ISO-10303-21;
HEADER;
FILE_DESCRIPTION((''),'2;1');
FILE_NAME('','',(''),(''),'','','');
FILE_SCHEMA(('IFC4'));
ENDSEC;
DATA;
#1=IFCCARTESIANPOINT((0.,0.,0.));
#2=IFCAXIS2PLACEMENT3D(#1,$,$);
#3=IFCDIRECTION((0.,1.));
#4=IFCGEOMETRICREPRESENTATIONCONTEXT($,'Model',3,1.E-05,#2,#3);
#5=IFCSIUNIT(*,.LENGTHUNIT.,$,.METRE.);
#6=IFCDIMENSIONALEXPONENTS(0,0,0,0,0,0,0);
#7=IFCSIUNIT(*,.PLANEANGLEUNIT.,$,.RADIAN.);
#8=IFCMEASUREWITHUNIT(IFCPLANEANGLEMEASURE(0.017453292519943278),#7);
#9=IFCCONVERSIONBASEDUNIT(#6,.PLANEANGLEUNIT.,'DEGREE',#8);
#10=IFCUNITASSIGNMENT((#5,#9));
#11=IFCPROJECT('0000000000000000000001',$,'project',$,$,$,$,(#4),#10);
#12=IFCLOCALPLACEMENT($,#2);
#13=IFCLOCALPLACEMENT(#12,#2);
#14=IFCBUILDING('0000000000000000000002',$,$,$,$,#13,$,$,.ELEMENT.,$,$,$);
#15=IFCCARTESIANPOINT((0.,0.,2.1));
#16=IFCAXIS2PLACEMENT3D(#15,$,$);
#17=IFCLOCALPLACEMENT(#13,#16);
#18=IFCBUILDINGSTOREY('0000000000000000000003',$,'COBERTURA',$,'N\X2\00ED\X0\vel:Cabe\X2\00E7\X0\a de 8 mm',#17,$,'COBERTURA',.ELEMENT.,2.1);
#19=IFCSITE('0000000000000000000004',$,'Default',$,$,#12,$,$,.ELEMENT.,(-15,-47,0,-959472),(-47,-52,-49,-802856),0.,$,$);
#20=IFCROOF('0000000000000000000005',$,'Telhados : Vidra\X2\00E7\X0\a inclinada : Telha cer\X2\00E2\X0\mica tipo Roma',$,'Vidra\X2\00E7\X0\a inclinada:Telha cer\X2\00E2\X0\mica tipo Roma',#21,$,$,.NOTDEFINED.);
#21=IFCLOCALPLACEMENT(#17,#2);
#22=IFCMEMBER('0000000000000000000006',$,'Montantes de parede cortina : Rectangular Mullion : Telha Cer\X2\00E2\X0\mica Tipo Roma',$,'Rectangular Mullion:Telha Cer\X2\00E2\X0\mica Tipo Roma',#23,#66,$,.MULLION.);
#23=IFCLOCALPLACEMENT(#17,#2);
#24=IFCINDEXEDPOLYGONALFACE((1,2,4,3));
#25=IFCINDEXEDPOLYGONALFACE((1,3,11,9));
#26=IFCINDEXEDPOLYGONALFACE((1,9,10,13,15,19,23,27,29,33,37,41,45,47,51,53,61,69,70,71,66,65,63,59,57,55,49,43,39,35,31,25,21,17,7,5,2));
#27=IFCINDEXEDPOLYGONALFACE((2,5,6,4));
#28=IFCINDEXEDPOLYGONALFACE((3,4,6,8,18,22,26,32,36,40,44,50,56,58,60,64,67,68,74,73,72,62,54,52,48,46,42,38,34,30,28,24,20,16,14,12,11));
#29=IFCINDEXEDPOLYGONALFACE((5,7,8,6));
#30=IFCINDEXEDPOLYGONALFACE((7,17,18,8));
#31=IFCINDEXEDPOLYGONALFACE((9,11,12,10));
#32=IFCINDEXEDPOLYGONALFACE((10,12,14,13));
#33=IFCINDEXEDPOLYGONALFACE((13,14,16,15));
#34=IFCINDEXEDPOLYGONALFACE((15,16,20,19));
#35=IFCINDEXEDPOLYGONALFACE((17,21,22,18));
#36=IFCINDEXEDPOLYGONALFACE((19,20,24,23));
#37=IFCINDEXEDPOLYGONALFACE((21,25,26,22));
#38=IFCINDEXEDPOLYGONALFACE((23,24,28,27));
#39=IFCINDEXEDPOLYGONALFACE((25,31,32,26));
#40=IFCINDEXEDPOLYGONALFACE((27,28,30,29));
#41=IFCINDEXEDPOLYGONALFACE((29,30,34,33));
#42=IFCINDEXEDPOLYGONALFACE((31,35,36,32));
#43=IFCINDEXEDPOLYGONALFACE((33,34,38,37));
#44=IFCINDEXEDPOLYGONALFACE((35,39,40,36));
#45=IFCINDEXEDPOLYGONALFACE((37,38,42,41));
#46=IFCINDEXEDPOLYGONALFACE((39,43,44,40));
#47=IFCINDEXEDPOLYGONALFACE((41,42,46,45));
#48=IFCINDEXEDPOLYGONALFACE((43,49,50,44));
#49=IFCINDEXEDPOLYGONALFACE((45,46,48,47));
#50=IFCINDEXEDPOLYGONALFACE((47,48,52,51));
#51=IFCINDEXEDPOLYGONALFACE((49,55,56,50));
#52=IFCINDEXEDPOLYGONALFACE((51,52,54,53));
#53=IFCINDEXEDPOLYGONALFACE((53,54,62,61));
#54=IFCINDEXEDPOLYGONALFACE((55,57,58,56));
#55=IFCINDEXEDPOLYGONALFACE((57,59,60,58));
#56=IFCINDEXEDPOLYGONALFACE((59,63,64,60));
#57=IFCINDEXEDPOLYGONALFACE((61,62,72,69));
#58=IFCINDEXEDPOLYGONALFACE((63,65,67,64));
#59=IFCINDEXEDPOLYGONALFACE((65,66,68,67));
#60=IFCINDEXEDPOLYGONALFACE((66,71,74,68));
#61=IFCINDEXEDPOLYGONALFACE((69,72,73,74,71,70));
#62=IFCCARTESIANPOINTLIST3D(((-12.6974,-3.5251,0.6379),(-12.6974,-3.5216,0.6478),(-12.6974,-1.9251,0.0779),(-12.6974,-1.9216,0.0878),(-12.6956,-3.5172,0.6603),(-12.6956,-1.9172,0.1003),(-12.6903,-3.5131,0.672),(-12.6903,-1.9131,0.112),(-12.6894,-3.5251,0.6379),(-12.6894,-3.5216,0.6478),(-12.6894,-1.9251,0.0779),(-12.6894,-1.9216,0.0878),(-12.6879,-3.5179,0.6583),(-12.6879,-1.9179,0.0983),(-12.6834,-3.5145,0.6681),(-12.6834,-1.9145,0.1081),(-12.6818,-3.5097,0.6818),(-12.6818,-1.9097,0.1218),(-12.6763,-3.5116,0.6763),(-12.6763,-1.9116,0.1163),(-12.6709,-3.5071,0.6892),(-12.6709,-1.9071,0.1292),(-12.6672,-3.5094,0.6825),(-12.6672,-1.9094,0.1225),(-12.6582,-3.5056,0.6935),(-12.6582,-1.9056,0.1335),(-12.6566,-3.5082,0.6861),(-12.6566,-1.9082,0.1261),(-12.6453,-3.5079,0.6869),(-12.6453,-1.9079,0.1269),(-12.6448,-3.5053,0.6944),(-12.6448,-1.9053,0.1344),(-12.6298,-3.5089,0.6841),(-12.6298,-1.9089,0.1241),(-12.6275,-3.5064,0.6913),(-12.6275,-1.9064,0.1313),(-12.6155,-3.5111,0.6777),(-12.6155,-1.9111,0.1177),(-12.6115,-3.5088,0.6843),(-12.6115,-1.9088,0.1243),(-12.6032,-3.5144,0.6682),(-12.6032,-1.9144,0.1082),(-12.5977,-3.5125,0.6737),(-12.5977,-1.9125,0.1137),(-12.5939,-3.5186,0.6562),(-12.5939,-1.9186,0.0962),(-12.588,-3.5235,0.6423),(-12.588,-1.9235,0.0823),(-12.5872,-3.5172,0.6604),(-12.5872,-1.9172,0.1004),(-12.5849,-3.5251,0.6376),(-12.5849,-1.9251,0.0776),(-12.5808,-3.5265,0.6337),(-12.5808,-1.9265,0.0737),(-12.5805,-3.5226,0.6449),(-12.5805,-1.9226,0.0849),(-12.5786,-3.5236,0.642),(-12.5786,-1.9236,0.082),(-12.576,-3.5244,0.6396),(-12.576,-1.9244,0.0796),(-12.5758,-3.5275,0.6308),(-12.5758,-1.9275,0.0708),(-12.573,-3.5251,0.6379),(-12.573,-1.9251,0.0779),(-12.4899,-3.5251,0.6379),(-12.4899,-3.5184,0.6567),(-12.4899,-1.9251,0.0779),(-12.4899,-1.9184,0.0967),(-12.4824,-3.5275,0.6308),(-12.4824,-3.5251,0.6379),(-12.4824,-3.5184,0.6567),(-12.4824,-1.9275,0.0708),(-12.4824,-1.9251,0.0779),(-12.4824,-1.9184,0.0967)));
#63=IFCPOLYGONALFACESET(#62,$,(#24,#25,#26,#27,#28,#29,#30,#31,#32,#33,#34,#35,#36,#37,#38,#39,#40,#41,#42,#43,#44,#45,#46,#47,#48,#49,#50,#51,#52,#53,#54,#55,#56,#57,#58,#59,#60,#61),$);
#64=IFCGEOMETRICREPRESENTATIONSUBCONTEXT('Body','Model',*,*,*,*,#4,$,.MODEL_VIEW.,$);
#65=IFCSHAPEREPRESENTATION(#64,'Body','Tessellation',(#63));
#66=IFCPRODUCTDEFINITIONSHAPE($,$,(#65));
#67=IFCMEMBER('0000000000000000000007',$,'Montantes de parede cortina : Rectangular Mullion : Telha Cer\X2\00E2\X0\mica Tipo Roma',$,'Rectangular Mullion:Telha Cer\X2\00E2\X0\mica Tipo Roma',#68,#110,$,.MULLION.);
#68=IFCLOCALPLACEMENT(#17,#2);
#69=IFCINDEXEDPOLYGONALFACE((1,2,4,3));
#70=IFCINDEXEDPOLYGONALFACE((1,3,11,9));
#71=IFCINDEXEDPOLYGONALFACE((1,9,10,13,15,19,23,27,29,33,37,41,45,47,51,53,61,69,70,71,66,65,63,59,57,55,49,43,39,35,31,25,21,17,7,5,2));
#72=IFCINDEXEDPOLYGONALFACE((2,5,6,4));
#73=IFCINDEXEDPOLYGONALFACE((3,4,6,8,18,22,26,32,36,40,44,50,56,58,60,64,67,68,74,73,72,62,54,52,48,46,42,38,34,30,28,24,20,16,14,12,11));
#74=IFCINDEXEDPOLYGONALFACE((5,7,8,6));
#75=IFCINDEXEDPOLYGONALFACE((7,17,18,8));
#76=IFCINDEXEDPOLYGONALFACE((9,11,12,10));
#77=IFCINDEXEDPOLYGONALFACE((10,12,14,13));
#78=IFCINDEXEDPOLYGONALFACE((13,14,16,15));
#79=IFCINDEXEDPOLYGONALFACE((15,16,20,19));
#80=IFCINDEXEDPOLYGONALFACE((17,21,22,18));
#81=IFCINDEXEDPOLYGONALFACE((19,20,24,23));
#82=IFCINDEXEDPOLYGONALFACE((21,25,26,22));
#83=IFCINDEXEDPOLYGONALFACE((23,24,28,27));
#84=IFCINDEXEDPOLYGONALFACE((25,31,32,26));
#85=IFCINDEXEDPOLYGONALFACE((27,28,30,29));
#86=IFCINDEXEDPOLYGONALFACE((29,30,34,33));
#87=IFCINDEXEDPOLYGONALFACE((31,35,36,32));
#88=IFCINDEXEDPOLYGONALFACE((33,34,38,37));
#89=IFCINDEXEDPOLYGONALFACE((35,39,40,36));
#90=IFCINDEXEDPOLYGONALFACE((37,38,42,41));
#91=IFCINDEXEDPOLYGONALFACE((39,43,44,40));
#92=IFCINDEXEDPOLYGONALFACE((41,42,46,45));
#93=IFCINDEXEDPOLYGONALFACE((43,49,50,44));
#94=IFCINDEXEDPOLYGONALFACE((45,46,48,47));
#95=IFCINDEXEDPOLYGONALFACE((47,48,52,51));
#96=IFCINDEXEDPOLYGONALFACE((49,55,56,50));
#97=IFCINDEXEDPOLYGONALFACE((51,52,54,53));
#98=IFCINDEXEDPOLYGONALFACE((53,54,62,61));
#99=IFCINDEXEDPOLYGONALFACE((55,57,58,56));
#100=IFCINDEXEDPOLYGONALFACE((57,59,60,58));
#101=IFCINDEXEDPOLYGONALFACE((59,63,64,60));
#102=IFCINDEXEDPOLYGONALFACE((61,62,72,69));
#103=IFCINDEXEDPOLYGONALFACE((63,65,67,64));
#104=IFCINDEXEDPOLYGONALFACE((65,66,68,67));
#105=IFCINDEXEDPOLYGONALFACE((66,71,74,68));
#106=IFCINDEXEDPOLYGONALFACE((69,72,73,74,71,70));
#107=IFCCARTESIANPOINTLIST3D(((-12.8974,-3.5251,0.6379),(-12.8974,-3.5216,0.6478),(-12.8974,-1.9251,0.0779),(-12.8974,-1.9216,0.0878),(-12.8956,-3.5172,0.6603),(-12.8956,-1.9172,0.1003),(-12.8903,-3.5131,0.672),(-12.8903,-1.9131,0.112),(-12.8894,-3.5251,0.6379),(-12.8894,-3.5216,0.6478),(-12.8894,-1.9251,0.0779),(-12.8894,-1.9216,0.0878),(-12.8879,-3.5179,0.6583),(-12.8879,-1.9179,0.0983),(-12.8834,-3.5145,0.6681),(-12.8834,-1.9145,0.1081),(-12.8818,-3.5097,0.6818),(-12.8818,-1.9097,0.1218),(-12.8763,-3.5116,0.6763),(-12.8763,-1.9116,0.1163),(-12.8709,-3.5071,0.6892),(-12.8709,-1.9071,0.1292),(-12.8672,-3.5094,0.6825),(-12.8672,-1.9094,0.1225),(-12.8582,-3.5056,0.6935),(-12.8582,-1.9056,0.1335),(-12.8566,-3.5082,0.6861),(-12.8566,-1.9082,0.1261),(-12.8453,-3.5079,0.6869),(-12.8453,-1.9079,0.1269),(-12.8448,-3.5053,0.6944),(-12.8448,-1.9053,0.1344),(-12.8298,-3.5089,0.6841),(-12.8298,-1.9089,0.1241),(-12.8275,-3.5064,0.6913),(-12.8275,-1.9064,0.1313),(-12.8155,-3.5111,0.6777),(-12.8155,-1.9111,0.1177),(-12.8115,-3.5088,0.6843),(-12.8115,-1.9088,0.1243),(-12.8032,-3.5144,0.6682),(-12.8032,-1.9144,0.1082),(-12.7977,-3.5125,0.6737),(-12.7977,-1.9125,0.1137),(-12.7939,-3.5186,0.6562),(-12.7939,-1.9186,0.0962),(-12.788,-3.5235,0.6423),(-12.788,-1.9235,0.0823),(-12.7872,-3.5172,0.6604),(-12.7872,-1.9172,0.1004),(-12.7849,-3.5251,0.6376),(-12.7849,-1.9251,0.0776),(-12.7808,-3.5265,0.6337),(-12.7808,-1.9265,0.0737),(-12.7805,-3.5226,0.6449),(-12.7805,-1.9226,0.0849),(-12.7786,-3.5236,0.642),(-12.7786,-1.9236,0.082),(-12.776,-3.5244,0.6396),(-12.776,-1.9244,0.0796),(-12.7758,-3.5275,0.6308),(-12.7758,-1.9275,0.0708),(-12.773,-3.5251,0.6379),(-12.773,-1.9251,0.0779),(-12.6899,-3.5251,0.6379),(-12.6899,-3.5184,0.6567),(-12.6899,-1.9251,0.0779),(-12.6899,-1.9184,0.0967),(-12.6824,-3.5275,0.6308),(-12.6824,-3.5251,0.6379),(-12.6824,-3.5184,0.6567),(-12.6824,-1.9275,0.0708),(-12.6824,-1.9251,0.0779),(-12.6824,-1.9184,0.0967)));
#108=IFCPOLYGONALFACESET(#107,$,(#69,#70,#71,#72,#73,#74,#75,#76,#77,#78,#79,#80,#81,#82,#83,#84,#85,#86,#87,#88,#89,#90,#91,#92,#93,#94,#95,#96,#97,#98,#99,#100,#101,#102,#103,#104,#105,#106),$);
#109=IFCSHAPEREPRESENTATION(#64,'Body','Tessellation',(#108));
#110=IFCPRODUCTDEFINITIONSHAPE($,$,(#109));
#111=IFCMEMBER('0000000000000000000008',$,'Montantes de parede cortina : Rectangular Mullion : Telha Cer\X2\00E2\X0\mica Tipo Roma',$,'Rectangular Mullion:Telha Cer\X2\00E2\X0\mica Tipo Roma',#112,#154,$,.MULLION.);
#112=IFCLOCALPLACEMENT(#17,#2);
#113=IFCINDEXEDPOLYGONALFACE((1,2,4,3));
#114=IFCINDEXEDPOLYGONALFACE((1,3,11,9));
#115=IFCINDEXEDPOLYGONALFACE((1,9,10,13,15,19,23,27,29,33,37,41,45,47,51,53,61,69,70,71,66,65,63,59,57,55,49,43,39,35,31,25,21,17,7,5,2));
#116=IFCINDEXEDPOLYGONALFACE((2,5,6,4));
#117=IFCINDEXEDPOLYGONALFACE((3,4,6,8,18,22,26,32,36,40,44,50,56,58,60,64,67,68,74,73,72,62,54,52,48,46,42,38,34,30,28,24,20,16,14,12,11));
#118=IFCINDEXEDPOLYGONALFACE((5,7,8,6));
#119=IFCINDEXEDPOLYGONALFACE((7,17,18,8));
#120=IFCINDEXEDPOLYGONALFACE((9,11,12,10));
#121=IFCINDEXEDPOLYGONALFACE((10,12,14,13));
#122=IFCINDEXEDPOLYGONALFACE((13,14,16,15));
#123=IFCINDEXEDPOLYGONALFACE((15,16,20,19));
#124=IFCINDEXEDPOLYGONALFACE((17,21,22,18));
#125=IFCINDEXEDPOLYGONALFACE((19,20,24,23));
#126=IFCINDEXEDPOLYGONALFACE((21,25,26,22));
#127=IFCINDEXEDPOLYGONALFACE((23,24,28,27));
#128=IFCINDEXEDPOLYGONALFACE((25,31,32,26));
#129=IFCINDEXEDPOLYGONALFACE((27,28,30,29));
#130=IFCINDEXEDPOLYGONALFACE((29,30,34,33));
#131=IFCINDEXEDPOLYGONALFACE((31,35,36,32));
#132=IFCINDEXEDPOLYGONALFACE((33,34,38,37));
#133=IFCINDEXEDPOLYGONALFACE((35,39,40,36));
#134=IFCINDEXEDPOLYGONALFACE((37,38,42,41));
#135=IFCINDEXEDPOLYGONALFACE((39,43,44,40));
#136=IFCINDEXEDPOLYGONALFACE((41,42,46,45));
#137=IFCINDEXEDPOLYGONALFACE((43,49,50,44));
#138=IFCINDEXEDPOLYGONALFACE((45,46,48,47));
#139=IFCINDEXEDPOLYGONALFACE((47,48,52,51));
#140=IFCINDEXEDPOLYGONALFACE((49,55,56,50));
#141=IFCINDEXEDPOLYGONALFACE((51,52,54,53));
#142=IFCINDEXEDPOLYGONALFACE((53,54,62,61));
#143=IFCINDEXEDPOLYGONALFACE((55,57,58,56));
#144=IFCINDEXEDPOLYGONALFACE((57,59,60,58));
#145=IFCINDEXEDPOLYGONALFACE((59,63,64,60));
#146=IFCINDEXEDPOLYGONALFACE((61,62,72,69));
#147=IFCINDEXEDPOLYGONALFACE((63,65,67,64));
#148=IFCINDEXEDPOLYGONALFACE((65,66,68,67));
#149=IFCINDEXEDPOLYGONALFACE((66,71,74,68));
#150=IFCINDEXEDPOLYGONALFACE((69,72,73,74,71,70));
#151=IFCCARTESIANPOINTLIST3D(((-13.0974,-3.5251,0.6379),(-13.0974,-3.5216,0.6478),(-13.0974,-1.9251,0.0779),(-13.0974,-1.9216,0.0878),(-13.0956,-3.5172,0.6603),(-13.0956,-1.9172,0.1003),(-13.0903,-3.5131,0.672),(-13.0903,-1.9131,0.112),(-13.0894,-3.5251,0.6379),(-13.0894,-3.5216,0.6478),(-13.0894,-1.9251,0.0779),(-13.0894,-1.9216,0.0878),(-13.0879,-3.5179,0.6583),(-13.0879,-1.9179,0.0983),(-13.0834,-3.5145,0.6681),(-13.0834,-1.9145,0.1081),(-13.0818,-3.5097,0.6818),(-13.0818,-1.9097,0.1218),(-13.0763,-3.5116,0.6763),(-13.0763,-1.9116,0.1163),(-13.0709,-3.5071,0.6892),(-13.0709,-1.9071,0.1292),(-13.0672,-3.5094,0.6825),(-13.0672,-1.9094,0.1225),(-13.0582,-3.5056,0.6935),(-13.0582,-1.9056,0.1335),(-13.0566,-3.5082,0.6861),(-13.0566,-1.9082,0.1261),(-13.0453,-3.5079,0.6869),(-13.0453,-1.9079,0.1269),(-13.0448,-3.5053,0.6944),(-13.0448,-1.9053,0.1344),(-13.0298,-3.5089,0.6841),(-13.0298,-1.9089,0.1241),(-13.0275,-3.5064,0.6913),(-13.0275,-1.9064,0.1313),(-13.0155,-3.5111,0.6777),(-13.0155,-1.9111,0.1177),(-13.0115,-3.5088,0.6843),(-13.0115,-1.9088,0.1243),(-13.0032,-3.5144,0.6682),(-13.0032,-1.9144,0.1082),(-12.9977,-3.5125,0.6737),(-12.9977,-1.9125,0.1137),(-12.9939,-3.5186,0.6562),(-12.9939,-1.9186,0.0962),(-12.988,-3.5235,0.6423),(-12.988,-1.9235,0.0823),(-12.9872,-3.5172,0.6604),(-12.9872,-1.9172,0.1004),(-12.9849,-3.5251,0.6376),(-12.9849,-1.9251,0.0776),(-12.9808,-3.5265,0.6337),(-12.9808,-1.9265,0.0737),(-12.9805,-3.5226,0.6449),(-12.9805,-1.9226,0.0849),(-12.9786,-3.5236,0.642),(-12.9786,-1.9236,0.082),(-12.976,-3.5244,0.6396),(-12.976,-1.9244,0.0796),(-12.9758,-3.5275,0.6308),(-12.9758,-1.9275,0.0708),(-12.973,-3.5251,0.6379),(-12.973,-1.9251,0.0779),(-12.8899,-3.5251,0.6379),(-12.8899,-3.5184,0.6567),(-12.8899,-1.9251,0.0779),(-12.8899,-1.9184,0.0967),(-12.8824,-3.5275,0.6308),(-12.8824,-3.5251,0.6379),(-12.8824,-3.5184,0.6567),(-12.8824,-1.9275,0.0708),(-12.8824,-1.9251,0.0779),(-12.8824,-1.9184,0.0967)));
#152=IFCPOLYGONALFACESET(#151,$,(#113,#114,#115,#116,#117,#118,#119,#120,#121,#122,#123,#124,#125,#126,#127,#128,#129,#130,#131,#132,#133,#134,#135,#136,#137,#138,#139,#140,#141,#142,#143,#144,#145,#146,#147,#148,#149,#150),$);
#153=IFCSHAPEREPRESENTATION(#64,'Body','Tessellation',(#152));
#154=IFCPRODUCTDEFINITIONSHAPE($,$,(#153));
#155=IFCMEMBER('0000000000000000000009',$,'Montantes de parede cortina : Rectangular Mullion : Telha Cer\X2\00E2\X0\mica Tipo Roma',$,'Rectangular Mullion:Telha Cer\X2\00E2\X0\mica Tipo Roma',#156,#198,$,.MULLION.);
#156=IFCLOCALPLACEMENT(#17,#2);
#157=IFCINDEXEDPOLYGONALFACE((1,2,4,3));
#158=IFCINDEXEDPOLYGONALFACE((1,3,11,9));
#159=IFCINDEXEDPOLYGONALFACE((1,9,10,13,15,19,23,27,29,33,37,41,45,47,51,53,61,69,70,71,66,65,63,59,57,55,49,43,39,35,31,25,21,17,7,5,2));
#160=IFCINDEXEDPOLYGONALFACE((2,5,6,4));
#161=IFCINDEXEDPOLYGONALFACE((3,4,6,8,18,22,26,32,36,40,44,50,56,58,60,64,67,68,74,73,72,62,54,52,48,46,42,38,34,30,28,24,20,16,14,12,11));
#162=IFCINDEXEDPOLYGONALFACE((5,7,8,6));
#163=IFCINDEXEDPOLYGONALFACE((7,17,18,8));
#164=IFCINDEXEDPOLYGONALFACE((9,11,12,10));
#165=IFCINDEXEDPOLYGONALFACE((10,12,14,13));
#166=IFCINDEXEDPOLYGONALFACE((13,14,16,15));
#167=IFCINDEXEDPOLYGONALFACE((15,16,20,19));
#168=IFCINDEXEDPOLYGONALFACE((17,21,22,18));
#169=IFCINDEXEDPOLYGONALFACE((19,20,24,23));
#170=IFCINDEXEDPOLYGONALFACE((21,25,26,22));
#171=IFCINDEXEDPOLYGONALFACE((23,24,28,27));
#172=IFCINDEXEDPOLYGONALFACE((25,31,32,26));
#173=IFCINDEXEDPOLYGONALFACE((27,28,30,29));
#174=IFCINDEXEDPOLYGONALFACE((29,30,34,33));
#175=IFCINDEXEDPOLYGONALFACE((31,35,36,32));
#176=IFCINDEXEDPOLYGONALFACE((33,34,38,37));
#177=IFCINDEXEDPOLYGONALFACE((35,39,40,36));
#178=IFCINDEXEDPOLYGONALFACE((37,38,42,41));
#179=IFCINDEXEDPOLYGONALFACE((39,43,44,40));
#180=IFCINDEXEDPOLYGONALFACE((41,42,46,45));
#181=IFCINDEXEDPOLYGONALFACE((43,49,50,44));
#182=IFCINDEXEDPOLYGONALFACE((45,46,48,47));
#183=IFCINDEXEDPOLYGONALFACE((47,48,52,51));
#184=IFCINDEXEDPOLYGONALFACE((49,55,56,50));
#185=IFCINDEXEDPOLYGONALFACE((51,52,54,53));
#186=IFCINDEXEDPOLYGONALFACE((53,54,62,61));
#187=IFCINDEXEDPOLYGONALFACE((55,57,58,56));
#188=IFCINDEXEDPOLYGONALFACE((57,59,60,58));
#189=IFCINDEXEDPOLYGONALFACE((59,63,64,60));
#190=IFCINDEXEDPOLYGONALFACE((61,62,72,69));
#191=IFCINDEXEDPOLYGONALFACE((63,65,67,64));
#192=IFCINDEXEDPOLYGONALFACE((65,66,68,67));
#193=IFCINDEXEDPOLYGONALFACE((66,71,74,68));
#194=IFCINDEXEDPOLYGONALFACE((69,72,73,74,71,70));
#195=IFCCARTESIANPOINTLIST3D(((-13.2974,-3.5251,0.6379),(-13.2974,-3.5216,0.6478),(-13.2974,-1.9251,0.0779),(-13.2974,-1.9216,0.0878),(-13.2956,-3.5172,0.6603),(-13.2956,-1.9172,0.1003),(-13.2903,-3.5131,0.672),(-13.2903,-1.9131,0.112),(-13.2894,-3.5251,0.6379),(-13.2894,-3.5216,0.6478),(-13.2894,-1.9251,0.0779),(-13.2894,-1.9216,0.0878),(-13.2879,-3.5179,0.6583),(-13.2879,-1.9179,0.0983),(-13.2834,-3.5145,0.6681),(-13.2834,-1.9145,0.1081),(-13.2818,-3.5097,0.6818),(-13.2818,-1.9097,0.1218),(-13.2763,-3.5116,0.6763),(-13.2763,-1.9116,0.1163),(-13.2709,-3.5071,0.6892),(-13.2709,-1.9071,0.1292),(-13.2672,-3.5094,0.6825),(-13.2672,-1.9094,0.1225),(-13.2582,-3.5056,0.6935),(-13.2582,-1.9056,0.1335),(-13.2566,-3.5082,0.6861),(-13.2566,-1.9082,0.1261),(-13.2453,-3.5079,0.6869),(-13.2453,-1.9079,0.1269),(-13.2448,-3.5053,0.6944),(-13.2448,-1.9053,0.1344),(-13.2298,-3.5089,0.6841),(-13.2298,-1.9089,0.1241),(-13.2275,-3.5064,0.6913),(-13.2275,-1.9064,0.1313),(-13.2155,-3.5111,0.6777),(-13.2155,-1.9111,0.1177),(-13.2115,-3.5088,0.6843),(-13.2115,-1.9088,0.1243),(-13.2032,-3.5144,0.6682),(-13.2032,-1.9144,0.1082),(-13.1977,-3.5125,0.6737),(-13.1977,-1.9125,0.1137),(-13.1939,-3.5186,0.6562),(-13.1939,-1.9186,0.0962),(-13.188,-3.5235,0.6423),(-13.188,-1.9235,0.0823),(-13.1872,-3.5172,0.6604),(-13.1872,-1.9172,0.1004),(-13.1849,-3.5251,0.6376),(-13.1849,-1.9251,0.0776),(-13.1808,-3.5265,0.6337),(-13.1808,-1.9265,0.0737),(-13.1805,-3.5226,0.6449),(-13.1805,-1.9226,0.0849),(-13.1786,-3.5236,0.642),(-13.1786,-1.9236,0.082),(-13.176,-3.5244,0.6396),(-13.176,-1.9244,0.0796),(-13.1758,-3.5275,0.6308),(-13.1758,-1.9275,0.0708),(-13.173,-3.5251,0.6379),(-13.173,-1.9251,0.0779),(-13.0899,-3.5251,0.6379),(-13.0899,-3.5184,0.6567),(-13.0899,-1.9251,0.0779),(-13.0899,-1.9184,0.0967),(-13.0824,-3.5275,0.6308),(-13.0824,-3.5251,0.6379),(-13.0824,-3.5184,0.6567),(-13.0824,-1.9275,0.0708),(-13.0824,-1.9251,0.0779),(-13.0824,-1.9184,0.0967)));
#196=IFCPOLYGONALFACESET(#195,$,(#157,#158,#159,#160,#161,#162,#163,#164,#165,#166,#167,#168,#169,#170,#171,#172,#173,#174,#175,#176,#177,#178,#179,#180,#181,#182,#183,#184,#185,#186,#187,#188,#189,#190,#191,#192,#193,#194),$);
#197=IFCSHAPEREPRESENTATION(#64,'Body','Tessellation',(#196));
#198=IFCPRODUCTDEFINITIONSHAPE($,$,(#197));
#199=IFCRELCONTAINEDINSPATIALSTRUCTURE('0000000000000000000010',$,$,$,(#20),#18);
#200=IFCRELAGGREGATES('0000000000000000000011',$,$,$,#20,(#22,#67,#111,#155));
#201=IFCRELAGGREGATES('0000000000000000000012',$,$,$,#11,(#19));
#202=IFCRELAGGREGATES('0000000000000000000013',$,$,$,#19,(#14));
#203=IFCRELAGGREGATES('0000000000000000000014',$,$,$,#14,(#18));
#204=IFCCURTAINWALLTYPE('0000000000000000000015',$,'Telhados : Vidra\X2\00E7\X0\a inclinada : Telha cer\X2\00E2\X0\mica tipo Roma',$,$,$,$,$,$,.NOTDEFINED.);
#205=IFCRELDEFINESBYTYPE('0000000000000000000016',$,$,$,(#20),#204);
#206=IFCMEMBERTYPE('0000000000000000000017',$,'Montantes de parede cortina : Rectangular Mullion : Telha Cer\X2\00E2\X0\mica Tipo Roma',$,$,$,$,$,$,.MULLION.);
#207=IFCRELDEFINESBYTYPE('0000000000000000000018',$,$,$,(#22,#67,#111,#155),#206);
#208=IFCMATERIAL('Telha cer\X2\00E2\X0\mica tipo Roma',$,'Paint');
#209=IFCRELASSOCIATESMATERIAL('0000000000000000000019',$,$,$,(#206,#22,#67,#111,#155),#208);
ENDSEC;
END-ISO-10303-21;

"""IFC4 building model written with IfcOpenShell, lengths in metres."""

from ifc_helpers import new_model, entity, si_unit, converted_unit, direction, frame, origin, place, context, subcontext, project, spatial, line, arc, indexed_curve, outline, extrude, source, transform, mapped, material, type_object, type_shapes, element, aggregate, save


model = new_model("IFC4")

# Units and contexts
model_context = context("Model", 3, precision=1e-05, world=origin(), true_north=direction((0.0, 1.0)))
body_context = subcontext(model_context, "Body", "Model", "MODEL_VIEW")
ifc_project = project(units=[si_unit("LENGTHUNIT", "METRE"), converted_unit("PLANEANGLEUNIT", "DEGREE", entity("IfcPlaneAngleMeasure", 0.017453292519943278), si_unit("PLANEANGLEUNIT", "RADIAN"), dimensions=[0, 0, 0, 0, 0, 0, 0])], contexts=[model_context])

# Site, building, storey
site_placement = place(None, origin())
site = spatial("IfcSite", under=ifc_project, at=site_placement, Name="Default", CompositionType="ELEMENT", RefLatitude=(-15, -47, 0, -959472), RefLongitude=(-47, -52, -49, -802856), RefElevation=0.0)
building_placement = place(site_placement, origin())
building = spatial("IfcBuilding", under=site, at=building_placement, CompositionType="ELEMENT")
storey_placement = place(building_placement, frame((0.0, 0.0, 2.1)))
storey = spatial("IfcBuildingStorey", under=building, at=storey_placement, Name="COBERTURA", ObjectType="Nível:Cabeça de 8 mm", LongName="COBERTURA", CompositionType="ELEMENT", Elevation=2.1)

# Roof, members
curtain_wall_type_1 = type_object("IfcCurtainWallType", Name="Telhados : Vidraça inclinada : Telha cerâmica tipo Roma", PredefinedType="NOTDEFINED")
roof_1_placement = place(storey_placement, frame((0.0, 0.0, -2.1)))
roof_1 = element("IfcRoof", 1, at=roof_1_placement, inside=storey, type_object=curtain_wall_type_1, Name="Telhados : Vidraça inclinada : Telha cerâmica tipo Roma", ObjectType="Vidraça inclinada:Telha cerâmica tipo Roma", PredefinedType="NOTDEFINED")
ifc_material_1 = material(Name="Telha cerâmica tipo Roma", Category="Paint")
member_type_1 = type_object("IfcMemberType", Name="Montantes de parede cortina : Rectangular Mullion : Telha Cerâmica Tipo Roma", PredefinedType="MULLION", material=ifc_material_1)
shared_shape_1 = source(origin(), body_context, "Body", "SweptSolid", [
    extrude(outline(indexed_curve([(0.0114, -0.0188), (0.1048, -0.0188), (0.1048, -0.0113), (0.1048, 0.0087), (0.0973, 0.0087), (0.0973, -0.0113), (0.0142, -0.0113), (0.0098, -0.0083), (0.0067, -0.0038), (-0.017, 0.0327), (-0.0576, 0.0486), (-0.0946, 0.0352), (-0.1102, -0.0008), (-0.1102, -0.0113), (-0.1022, -0.0113), (-0.1022, -0.0008), (-0.0891, 0.0294), (-0.0581, 0.0406), (-0.0218, 0.0263), (-0.0008, -0.0066), (0.0042, -0.0138)], segments=[line(1, 2, 3, 4, 5, 6, 7), arc(7, 8, 9), arc(9, 10, 11), arc(11, 12, 13), line(13, 14, 15, 16), arc(16, 17, 18), arc(18, 19, 20), arc(20, 21, 1)], self_intersect=False)), frame((-0.0027, -0.0938, -4.3552), z_axis=(0.0, 0.0, 1.0), x_axis=(-1.0, 0.0, 0.0)), (0.0, 0.0, 1.0), 1.6952),
])
type_shapes(member_type_1, [shared_shape_1])
member_1_placement = place(roof_1_placement, frame((-12.5899, -6.063, 3.5387), z_axis=(0.0, -0.943858, 0.33035), x_axis=(-1.0, 0.0, 0.0)))
member_1 = element("IfcMember", 2, at=member_1_placement, type_object=member_type_1, material=ifc_material_1, Name="Montantes de parede cortina : Rectangular Mullion : Telha Cerâmica Tipo Roma", ObjectType="Rectangular Mullion:Telha Cerâmica Tipo Roma", PredefinedType="MULLION", context=body_context, shape_type="MappedRepresentation", body=[
    mapped(shared_shape_1, transform((0.0, 0.0, 0.0), scale=1.0)),
])
member_2_placement = place(roof_1_placement, frame((-12.7899, -6.063, 3.5387), z_axis=(0.0, -0.943858, 0.33035), x_axis=(-1.0, 0.0, 0.0)))
member_2 = element("IfcMember", 3, at=member_2_placement, type_object=member_type_1, material=ifc_material_1, Name="Montantes de parede cortina : Rectangular Mullion : Telha Cerâmica Tipo Roma", ObjectType="Rectangular Mullion:Telha Cerâmica Tipo Roma", PredefinedType="MULLION", context=body_context, shape_type="MappedRepresentation", body=[
    mapped(shared_shape_1, transform((0.0, 0.0, 0.0), scale=1.0)),
])
member_3_placement = place(roof_1_placement, frame((-12.9899, -6.063, 3.5387), z_axis=(0.0, -0.943858, 0.33035), x_axis=(-1.0, 0.0, 0.0)))
member_3 = element("IfcMember", 4, at=member_3_placement, type_object=member_type_1, material=ifc_material_1, Name="Montantes de parede cortina : Rectangular Mullion : Telha Cerâmica Tipo Roma", ObjectType="Rectangular Mullion:Telha Cerâmica Tipo Roma", PredefinedType="MULLION", context=body_context, shape_type="MappedRepresentation", body=[
    mapped(shared_shape_1, transform((0.0, 0.0, 0.0), scale=1.0)),
])
member_4_placement = place(roof_1_placement, frame((-13.1899, -6.063, 3.5387), z_axis=(0.0, -0.943858, 0.33035), x_axis=(-1.0, 0.0, 0.0)))
member_4 = element("IfcMember", 5, at=member_4_placement, type_object=member_type_1, material=ifc_material_1, Name="Montantes de parede cortina : Rectangular Mullion : Telha Cerâmica Tipo Roma", ObjectType="Rectangular Mullion:Telha Cerâmica Tipo Roma", PredefinedType="MULLION", context=body_context, shape_type="MappedRepresentation", body=[
    mapped(shared_shape_1, transform((0.0, 0.0, 0.0), scale=1.0)),
])
aggregate(roof_1, [member_1, member_2, member_3, member_4])

save(model, "model.ifc")
